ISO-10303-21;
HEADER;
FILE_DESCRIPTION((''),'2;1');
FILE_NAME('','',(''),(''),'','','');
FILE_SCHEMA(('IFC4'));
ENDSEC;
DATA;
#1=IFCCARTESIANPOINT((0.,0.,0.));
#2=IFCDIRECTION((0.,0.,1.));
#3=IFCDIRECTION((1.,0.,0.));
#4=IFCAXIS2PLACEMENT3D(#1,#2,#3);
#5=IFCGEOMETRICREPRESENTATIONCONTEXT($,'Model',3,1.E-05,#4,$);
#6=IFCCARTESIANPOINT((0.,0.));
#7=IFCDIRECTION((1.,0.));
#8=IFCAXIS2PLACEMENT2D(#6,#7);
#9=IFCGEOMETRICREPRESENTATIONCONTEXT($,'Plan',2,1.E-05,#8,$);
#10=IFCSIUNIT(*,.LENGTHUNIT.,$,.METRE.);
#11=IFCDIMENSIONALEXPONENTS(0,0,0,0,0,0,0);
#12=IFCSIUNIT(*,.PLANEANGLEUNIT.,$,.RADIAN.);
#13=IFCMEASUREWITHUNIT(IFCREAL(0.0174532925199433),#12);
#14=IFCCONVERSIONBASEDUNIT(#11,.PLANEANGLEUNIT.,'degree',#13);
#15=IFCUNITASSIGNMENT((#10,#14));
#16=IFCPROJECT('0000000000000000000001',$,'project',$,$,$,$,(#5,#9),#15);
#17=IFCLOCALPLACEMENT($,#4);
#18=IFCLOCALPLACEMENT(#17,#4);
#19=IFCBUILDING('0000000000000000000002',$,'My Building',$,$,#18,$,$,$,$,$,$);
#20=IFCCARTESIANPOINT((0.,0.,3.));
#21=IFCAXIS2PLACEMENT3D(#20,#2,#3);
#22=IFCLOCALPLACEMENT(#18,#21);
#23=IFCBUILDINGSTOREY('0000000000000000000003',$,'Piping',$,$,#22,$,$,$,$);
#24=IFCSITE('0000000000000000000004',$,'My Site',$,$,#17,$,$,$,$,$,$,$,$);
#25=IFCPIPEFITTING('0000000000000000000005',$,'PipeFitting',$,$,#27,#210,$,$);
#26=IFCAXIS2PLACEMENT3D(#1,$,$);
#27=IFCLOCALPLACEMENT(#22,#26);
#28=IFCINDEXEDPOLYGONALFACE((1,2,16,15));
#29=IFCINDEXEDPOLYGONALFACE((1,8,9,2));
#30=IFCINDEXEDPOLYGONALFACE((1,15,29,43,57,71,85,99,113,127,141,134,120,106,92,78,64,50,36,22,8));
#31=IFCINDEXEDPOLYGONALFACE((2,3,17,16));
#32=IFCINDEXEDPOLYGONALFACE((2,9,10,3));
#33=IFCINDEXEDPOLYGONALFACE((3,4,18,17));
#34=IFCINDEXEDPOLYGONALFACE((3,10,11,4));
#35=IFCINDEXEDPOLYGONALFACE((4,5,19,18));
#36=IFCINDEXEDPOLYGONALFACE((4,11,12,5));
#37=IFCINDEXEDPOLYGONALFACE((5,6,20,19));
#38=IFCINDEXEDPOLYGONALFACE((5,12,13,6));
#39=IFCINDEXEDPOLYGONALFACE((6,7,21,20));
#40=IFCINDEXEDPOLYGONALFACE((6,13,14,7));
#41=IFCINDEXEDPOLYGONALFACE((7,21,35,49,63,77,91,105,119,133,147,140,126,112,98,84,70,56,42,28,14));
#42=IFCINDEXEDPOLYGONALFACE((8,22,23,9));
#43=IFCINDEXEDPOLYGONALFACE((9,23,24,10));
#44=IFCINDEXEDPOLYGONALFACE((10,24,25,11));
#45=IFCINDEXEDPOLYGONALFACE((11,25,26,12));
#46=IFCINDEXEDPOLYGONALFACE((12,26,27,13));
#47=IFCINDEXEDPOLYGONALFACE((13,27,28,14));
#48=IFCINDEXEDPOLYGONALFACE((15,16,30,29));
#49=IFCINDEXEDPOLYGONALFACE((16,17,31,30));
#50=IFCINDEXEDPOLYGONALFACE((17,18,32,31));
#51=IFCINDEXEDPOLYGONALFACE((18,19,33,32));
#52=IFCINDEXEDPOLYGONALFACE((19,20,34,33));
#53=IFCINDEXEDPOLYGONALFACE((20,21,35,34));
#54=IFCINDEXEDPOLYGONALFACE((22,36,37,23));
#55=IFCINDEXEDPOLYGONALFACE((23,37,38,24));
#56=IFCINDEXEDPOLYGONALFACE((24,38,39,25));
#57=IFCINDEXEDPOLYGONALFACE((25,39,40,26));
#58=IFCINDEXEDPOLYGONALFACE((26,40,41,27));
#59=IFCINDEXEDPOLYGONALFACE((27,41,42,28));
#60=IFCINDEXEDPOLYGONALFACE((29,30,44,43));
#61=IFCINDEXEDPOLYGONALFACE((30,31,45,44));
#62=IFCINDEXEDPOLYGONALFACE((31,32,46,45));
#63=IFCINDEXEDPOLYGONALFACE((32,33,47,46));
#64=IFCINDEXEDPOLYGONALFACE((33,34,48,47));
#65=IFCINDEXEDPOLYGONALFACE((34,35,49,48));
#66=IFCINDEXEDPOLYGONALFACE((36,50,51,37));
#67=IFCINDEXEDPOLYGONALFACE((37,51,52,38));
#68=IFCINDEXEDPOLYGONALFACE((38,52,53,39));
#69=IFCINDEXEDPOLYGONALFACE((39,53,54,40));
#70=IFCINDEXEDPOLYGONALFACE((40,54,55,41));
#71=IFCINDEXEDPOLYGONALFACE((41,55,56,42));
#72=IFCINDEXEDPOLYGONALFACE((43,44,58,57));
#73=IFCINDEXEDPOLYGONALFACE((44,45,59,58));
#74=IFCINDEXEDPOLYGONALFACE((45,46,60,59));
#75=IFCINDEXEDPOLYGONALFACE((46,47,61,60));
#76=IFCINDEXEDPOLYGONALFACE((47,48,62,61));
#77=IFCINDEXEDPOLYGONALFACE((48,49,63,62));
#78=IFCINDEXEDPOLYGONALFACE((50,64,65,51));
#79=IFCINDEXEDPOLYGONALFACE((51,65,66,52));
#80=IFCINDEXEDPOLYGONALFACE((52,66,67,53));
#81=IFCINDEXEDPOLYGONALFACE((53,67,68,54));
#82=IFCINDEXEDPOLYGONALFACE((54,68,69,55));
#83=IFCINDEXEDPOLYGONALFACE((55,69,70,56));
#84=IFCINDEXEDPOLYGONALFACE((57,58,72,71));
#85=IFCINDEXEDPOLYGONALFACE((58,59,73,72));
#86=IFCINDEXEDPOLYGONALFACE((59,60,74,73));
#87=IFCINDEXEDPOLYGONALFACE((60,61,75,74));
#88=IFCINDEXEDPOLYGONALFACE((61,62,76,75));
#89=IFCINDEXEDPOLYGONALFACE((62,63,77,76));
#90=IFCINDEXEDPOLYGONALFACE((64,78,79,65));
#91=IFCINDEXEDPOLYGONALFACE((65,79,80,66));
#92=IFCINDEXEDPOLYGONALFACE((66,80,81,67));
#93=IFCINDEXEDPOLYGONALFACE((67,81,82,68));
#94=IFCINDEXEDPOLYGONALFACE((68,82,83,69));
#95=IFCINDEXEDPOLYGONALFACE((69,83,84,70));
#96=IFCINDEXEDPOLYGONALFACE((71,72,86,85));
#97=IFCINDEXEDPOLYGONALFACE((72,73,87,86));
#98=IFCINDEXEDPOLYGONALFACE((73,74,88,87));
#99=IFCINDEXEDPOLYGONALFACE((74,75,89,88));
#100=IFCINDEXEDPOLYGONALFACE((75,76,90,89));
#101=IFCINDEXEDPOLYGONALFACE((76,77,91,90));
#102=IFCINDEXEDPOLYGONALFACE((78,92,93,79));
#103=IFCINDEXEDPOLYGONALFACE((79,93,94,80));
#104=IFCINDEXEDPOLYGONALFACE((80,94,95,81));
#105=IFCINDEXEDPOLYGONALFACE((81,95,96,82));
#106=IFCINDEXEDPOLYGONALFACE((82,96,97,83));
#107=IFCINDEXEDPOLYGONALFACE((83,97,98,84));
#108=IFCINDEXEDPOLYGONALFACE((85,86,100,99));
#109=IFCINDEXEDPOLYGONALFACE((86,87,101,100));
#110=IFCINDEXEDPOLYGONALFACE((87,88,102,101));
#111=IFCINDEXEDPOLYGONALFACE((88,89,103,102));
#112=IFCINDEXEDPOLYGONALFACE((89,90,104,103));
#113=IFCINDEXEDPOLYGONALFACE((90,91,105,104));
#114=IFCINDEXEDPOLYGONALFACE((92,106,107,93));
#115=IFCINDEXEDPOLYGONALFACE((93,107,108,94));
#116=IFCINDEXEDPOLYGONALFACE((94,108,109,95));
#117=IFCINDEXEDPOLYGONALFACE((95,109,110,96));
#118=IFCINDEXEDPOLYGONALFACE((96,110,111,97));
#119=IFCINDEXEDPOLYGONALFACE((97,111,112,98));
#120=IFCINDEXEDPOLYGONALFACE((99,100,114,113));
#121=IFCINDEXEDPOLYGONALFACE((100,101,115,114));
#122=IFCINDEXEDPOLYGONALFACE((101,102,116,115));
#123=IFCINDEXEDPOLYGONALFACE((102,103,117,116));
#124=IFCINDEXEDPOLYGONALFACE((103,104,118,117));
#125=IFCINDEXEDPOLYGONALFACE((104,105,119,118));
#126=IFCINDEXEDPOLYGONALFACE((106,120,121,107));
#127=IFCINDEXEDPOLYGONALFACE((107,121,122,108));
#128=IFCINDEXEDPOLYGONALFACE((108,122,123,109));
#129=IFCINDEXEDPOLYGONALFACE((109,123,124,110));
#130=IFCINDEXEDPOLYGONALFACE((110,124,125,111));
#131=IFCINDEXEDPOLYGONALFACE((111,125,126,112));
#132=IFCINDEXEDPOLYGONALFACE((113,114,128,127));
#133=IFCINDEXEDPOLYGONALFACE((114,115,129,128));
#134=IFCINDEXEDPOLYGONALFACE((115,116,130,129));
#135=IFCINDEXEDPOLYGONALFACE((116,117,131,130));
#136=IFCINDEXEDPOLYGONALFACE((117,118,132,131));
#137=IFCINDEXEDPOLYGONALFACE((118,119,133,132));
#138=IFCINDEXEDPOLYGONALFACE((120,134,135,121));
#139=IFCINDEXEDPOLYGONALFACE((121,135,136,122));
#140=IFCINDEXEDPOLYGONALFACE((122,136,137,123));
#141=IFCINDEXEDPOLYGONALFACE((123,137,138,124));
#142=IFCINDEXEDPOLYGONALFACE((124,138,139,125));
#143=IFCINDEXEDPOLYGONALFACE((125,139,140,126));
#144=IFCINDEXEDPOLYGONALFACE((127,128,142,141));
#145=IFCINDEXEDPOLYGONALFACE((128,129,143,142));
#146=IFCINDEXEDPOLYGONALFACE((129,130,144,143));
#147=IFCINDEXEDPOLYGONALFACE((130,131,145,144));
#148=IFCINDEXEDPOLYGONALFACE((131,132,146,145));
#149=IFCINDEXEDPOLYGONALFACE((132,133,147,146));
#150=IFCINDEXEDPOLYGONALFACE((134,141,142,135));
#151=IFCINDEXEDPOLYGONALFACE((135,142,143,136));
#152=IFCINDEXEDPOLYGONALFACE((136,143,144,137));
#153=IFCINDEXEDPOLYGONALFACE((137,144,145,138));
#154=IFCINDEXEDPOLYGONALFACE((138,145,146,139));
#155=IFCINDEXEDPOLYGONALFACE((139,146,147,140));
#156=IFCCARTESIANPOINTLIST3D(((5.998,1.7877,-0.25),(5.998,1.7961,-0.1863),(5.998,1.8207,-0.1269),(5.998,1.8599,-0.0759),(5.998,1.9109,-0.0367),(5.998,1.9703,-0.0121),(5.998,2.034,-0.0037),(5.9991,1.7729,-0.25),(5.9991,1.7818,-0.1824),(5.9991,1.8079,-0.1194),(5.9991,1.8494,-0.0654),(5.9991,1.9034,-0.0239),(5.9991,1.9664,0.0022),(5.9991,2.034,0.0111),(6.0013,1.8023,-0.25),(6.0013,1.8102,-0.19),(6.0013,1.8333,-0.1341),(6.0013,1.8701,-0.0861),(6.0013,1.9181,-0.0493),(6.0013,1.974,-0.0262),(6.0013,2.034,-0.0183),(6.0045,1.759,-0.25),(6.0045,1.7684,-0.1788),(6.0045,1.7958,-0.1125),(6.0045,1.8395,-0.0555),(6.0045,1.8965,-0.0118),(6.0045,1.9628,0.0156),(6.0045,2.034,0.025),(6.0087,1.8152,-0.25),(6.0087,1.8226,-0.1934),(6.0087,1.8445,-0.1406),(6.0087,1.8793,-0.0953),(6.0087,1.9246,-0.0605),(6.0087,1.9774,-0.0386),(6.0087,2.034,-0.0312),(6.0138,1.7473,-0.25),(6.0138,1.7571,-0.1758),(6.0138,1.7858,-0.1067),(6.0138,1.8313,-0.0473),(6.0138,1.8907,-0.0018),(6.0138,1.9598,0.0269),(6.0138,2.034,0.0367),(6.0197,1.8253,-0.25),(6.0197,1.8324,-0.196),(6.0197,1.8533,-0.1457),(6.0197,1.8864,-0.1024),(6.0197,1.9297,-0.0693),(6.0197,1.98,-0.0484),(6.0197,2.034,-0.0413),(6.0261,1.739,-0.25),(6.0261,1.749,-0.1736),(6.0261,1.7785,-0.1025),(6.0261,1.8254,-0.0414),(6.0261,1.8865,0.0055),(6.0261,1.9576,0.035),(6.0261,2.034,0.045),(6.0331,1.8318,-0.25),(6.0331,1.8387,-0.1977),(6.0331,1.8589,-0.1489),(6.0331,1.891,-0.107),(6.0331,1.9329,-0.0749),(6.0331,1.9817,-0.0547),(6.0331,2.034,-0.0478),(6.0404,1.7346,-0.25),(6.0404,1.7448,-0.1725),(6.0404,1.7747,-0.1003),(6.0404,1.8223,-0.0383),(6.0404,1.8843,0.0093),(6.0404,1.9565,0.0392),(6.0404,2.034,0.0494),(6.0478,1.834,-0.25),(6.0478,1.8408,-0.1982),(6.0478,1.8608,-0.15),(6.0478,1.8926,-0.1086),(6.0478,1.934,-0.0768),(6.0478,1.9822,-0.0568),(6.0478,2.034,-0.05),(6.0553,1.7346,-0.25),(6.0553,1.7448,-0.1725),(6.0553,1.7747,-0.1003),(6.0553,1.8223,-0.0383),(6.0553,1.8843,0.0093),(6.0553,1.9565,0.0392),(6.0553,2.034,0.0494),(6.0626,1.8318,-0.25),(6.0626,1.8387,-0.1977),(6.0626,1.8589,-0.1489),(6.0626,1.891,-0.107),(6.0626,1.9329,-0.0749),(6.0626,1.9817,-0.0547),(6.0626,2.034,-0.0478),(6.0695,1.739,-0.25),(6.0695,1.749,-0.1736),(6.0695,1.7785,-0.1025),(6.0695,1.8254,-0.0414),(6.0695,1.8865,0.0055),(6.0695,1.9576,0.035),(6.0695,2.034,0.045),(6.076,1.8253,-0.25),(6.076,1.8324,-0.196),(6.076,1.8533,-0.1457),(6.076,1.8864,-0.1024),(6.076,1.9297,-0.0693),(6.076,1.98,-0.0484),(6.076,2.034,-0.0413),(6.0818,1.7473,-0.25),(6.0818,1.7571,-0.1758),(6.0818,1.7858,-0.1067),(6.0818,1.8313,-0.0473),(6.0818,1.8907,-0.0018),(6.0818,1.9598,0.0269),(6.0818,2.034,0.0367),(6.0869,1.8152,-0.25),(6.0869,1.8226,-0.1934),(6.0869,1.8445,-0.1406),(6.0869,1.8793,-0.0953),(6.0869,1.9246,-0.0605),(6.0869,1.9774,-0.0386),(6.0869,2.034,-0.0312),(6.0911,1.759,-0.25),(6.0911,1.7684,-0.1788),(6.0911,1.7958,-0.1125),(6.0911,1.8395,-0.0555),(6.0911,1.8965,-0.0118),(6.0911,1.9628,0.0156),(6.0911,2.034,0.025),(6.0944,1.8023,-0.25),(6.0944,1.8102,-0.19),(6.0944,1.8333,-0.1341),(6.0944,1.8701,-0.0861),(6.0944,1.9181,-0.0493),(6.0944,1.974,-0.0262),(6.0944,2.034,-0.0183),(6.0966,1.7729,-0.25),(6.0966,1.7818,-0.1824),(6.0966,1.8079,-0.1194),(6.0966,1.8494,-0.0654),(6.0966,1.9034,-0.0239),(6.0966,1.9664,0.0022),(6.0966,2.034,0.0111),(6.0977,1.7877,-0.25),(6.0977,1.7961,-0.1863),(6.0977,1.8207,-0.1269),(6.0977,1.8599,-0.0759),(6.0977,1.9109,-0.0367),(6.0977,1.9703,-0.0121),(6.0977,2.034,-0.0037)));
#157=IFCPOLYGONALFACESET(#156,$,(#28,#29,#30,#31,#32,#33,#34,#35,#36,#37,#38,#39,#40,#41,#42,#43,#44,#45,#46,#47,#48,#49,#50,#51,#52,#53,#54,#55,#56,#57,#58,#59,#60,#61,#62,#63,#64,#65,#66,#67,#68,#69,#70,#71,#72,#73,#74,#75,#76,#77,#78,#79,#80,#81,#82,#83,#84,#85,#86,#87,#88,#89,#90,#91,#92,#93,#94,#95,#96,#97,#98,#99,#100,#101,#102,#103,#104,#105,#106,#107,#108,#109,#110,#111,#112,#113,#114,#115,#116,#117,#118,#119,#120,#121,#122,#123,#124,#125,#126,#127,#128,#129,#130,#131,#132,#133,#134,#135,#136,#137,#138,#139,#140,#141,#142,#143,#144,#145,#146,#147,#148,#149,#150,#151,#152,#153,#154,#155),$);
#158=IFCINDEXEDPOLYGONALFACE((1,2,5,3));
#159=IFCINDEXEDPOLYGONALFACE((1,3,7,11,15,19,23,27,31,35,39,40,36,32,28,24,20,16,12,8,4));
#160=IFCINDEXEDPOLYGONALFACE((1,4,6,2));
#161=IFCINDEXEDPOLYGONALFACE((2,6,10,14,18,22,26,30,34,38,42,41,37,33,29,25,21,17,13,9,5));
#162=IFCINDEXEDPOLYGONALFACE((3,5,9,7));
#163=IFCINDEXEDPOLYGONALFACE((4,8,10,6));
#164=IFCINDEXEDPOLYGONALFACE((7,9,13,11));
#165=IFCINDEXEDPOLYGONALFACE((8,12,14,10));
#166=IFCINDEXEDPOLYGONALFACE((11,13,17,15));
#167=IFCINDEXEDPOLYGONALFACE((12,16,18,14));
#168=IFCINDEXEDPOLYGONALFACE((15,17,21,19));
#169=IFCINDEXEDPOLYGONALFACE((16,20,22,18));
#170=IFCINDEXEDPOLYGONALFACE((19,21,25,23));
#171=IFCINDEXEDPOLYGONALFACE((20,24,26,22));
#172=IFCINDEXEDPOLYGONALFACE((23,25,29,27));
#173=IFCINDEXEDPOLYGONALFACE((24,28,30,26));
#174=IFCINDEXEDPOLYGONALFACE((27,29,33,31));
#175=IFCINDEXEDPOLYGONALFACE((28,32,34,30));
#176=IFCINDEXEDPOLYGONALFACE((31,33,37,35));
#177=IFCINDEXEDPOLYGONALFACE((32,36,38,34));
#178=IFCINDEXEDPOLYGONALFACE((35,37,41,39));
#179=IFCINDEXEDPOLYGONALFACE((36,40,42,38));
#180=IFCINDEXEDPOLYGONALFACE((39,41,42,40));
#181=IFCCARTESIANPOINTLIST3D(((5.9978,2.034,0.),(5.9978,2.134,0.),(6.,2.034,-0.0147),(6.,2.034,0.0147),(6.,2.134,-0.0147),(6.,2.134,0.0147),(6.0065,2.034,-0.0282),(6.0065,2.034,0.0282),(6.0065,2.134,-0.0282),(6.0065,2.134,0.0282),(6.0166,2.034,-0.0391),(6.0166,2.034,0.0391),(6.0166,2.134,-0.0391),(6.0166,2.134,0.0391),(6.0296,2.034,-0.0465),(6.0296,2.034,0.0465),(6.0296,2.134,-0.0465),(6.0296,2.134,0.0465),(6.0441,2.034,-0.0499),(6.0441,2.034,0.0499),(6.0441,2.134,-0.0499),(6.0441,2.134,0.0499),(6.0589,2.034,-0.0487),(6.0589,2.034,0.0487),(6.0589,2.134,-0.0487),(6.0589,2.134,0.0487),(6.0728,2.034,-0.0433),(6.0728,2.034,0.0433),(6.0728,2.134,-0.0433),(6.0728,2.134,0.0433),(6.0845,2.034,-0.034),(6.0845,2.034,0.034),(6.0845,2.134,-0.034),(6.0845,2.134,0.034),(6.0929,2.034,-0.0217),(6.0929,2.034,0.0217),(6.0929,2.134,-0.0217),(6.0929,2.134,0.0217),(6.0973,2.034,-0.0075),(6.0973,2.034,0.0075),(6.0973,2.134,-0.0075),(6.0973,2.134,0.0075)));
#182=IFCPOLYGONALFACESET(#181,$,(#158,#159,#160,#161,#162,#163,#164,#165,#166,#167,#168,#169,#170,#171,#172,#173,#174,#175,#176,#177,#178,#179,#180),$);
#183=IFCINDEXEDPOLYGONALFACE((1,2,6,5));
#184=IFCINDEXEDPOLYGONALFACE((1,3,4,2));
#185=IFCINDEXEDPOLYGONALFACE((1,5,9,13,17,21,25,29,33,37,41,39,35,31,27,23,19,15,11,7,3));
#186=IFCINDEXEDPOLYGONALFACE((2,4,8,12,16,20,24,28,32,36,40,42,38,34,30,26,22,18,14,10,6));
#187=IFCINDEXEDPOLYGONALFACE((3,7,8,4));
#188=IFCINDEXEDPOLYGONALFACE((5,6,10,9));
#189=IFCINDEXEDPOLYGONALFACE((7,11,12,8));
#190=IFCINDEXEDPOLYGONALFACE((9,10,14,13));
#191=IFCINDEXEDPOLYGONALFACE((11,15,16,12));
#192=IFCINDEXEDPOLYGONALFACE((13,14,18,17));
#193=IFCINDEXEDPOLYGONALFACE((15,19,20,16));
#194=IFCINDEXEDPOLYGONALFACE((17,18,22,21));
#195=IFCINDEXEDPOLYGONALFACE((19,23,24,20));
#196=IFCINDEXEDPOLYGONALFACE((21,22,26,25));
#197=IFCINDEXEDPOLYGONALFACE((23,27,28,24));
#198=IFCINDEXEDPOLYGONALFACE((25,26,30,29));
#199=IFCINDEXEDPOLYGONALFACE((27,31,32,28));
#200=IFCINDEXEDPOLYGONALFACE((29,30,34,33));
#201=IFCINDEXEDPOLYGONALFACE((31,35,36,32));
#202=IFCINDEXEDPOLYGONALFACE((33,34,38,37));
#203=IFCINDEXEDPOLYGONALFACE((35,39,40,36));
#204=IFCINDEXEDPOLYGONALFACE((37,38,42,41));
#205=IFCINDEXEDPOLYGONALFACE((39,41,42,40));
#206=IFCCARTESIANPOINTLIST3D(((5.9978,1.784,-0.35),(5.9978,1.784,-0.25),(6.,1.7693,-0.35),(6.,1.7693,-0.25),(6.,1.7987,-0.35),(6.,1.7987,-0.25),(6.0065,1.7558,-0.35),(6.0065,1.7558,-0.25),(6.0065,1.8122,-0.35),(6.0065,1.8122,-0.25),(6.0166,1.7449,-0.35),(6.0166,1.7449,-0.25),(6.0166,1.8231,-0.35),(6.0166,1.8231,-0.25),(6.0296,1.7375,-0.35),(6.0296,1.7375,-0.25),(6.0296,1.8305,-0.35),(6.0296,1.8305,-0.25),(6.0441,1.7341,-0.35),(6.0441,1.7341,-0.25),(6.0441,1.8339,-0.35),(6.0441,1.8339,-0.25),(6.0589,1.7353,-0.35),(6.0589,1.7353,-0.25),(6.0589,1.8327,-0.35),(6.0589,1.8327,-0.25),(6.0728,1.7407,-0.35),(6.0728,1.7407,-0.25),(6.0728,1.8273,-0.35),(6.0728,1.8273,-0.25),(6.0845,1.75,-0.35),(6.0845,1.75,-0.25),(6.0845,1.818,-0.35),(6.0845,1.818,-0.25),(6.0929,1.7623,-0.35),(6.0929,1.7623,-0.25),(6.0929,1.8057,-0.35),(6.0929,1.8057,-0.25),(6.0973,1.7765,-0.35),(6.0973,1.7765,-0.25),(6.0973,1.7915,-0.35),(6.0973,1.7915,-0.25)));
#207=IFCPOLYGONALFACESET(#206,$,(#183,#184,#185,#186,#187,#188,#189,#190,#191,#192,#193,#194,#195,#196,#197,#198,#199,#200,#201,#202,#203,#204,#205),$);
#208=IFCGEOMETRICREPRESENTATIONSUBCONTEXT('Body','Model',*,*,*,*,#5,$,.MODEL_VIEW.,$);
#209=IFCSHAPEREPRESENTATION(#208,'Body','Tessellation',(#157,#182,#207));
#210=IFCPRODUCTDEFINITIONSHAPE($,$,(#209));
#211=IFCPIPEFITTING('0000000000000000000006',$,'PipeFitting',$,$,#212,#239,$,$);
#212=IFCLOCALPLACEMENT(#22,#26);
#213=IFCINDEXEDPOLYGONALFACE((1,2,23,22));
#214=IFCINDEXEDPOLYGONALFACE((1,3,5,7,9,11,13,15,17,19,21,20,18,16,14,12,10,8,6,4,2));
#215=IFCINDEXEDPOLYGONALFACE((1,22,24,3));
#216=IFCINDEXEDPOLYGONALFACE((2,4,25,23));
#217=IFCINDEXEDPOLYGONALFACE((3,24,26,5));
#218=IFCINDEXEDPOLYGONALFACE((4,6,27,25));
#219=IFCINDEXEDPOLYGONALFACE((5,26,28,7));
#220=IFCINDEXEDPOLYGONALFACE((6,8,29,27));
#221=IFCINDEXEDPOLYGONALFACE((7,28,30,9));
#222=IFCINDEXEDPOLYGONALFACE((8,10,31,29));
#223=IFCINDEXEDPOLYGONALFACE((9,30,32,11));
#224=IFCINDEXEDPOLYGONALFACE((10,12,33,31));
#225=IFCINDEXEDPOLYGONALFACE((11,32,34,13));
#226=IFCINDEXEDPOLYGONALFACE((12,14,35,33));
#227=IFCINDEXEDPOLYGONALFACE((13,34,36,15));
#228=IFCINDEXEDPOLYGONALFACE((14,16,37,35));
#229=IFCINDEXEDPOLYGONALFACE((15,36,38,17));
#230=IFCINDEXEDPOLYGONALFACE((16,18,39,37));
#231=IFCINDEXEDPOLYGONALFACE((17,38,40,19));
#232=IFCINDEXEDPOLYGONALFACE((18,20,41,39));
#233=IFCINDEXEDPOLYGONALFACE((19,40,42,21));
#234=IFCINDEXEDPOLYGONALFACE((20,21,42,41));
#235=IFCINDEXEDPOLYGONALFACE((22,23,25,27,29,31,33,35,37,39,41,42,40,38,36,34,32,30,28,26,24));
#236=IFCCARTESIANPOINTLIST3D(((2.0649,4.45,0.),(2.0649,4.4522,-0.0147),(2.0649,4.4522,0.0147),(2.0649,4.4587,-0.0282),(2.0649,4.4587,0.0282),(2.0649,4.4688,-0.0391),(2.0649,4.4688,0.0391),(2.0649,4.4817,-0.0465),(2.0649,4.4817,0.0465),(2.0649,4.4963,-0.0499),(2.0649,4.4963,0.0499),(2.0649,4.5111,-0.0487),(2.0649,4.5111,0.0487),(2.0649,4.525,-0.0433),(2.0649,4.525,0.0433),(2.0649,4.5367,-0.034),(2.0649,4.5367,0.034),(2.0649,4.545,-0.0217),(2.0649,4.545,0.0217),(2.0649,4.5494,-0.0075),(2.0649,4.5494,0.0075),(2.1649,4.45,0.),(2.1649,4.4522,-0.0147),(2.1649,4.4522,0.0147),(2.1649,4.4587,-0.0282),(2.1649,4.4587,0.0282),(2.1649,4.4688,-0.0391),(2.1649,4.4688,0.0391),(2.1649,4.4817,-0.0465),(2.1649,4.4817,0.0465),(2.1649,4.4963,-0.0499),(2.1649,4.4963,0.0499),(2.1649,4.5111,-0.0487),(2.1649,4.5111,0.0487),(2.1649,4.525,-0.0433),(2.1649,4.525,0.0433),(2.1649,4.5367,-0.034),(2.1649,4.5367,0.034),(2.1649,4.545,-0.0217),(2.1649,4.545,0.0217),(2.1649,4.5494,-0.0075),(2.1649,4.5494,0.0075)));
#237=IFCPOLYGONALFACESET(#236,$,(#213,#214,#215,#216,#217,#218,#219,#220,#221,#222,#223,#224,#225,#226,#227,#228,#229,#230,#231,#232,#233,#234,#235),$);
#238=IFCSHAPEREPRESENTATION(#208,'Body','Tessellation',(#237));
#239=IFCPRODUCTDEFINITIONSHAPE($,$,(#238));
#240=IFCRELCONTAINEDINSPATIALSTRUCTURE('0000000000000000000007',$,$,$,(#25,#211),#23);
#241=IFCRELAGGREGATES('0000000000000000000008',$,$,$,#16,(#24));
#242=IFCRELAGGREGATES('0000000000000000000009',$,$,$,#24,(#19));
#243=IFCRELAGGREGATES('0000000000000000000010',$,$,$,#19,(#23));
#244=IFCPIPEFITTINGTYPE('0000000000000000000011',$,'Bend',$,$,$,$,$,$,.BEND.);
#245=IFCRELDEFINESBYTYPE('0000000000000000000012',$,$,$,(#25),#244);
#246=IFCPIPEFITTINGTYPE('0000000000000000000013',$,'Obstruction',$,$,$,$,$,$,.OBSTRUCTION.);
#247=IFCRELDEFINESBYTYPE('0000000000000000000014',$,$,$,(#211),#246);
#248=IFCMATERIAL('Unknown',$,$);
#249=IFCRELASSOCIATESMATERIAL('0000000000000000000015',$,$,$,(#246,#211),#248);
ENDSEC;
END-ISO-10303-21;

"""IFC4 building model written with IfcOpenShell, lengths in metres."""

from ifc_helpers import new_model, entity, si_unit, converted_unit, frame, origin_with_axes, origin_2d_with_axis, place, context, subcontext, project, spatial, circle, extrude, source, transform, mapped, material, material_profile, profile_set, profile_usage, type_object, type_shapes, element, save


model = new_model("IFC4")

# Units and contexts
model_context = context("Model", 3, precision=1e-05, world=origin_with_axes())
plan_context = context("Plan", 2, precision=1e-05, world=origin_2d_with_axis())
body_context = subcontext(model_context, "Body", "Model", "MODEL_VIEW")
ifc_project = project(units=[si_unit("LENGTHUNIT", "METRE"), converted_unit("PLANEANGLEUNIT", "degree", entity("IfcReal", 0.0174532925199433), si_unit("PLANEANGLEUNIT", "RADIAN"), dimensions=[0, 0, 0, 0, 0, 0, 0])], contexts=[model_context, plan_context])

# Site, building, storey
site_placement = place(None, origin_with_axes())
site = spatial("IfcSite", under=ifc_project, at=site_placement, Name="My Site")
building_placement = place(site_placement, origin_with_axes())
building = spatial("IfcBuilding", under=site, at=building_placement, Name="My Building")
storey_placement = place(building_placement, frame((0.0, 0.0, 3.0), z_axis=(0.0, 0.0, 1.0), x_axis=(1.0, 0.0, 0.0)))
storey = spatial("IfcBuildingStorey", under=building, at=storey_placement, Name="Piping")

# Shared definitions
ifc_material = material(Name="Unknown")

# Pipe fittings
pipe_fitting_type_1 = type_object("IfcPipeFittingType", Name="Bend", PredefinedType="BEND")
shared_shape = source(origin_with_axes(), body_context, "Body", "SolidModel", [
    entity("IfcSweptDiskSolid", entity("IfcIndexedPolyCurve", entity("IfcCartesianPointList3D", [[0.0, 0.0, -0.1], [0.0, -0.0732, -0.2768], [0.0, -0.25, -0.35]]), [entity("IfcArcIndex", [1, 2, 3])]), 0.05),
    extrude(circle(Radius=0.05), origin_with_axes(), (0.0, 0.0, -1.0), 0.1),
    extrude(circle(Radius=0.05), frame((0.0, -0.25, -0.35), z_axis=(0.0, -1.0, 0.0), x_axis=(1.0, 0.0, 0.0)), (0.0, 0.0, 1.0), 0.1),
])
type_shapes(pipe_fitting_type_1, [shared_shape])
for number, where, z_axis, x_axis, name in (
    (1, (6.0478, 2.134, 0.0), (0.0, 1.0, 0.0), (-1.0, 0.0, 0.0), "PipeFitting"),
):
    element("IfcPipeFitting", number, at=place(storey_placement, frame(where, z_axis=z_axis, x_axis=x_axis)), inside=storey, type_object=pipe_fitting_type_1, Name=name, context=body_context, shape_type="MappedRepresentation", body=[
        mapped(shared_shape, transform((0.0, 0.0, 0.0), x_axis=(1.0, 0.0, 0.0), y_axis=(0.0, 1.0, 0.0), z_axis=(0.0, 0.0, 1.0), scale=1.0)),
    ])
ifc_material_profile_1 = material_profile(ifc_material, circle(Radius=0.05))
ifc_profile_set_1 = profile_set([ifc_material_profile_1])
ifc_profile_usage_1 = profile_usage(ifc_profile_set_1, cardinal=5)
pipe_fitting_type_2 = type_object("IfcPipeFittingType", Name="Obstruction", PredefinedType="OBSTRUCTION", material=ifc_profile_set_1)
pipe_fitting_1_placement = place(storey_placement, frame((2.1649, 4.5, 0.0), z_axis=(-1.0, 0.0, 0.0), x_axis=(0.0, -1.0, 0.0)))
element("IfcPipeFitting", 2, at=pipe_fitting_1_placement, inside=storey, type_object=pipe_fitting_type_2, material=ifc_profile_usage_1, Name="PipeFitting", context=body_context, shape_type="SweptSolid", body=[
    extrude(circle(Radius=0.05), origin_with_axes(), (0.0, 0.0, 1.0), 0.1),
])

save(model, "model.ifc")
